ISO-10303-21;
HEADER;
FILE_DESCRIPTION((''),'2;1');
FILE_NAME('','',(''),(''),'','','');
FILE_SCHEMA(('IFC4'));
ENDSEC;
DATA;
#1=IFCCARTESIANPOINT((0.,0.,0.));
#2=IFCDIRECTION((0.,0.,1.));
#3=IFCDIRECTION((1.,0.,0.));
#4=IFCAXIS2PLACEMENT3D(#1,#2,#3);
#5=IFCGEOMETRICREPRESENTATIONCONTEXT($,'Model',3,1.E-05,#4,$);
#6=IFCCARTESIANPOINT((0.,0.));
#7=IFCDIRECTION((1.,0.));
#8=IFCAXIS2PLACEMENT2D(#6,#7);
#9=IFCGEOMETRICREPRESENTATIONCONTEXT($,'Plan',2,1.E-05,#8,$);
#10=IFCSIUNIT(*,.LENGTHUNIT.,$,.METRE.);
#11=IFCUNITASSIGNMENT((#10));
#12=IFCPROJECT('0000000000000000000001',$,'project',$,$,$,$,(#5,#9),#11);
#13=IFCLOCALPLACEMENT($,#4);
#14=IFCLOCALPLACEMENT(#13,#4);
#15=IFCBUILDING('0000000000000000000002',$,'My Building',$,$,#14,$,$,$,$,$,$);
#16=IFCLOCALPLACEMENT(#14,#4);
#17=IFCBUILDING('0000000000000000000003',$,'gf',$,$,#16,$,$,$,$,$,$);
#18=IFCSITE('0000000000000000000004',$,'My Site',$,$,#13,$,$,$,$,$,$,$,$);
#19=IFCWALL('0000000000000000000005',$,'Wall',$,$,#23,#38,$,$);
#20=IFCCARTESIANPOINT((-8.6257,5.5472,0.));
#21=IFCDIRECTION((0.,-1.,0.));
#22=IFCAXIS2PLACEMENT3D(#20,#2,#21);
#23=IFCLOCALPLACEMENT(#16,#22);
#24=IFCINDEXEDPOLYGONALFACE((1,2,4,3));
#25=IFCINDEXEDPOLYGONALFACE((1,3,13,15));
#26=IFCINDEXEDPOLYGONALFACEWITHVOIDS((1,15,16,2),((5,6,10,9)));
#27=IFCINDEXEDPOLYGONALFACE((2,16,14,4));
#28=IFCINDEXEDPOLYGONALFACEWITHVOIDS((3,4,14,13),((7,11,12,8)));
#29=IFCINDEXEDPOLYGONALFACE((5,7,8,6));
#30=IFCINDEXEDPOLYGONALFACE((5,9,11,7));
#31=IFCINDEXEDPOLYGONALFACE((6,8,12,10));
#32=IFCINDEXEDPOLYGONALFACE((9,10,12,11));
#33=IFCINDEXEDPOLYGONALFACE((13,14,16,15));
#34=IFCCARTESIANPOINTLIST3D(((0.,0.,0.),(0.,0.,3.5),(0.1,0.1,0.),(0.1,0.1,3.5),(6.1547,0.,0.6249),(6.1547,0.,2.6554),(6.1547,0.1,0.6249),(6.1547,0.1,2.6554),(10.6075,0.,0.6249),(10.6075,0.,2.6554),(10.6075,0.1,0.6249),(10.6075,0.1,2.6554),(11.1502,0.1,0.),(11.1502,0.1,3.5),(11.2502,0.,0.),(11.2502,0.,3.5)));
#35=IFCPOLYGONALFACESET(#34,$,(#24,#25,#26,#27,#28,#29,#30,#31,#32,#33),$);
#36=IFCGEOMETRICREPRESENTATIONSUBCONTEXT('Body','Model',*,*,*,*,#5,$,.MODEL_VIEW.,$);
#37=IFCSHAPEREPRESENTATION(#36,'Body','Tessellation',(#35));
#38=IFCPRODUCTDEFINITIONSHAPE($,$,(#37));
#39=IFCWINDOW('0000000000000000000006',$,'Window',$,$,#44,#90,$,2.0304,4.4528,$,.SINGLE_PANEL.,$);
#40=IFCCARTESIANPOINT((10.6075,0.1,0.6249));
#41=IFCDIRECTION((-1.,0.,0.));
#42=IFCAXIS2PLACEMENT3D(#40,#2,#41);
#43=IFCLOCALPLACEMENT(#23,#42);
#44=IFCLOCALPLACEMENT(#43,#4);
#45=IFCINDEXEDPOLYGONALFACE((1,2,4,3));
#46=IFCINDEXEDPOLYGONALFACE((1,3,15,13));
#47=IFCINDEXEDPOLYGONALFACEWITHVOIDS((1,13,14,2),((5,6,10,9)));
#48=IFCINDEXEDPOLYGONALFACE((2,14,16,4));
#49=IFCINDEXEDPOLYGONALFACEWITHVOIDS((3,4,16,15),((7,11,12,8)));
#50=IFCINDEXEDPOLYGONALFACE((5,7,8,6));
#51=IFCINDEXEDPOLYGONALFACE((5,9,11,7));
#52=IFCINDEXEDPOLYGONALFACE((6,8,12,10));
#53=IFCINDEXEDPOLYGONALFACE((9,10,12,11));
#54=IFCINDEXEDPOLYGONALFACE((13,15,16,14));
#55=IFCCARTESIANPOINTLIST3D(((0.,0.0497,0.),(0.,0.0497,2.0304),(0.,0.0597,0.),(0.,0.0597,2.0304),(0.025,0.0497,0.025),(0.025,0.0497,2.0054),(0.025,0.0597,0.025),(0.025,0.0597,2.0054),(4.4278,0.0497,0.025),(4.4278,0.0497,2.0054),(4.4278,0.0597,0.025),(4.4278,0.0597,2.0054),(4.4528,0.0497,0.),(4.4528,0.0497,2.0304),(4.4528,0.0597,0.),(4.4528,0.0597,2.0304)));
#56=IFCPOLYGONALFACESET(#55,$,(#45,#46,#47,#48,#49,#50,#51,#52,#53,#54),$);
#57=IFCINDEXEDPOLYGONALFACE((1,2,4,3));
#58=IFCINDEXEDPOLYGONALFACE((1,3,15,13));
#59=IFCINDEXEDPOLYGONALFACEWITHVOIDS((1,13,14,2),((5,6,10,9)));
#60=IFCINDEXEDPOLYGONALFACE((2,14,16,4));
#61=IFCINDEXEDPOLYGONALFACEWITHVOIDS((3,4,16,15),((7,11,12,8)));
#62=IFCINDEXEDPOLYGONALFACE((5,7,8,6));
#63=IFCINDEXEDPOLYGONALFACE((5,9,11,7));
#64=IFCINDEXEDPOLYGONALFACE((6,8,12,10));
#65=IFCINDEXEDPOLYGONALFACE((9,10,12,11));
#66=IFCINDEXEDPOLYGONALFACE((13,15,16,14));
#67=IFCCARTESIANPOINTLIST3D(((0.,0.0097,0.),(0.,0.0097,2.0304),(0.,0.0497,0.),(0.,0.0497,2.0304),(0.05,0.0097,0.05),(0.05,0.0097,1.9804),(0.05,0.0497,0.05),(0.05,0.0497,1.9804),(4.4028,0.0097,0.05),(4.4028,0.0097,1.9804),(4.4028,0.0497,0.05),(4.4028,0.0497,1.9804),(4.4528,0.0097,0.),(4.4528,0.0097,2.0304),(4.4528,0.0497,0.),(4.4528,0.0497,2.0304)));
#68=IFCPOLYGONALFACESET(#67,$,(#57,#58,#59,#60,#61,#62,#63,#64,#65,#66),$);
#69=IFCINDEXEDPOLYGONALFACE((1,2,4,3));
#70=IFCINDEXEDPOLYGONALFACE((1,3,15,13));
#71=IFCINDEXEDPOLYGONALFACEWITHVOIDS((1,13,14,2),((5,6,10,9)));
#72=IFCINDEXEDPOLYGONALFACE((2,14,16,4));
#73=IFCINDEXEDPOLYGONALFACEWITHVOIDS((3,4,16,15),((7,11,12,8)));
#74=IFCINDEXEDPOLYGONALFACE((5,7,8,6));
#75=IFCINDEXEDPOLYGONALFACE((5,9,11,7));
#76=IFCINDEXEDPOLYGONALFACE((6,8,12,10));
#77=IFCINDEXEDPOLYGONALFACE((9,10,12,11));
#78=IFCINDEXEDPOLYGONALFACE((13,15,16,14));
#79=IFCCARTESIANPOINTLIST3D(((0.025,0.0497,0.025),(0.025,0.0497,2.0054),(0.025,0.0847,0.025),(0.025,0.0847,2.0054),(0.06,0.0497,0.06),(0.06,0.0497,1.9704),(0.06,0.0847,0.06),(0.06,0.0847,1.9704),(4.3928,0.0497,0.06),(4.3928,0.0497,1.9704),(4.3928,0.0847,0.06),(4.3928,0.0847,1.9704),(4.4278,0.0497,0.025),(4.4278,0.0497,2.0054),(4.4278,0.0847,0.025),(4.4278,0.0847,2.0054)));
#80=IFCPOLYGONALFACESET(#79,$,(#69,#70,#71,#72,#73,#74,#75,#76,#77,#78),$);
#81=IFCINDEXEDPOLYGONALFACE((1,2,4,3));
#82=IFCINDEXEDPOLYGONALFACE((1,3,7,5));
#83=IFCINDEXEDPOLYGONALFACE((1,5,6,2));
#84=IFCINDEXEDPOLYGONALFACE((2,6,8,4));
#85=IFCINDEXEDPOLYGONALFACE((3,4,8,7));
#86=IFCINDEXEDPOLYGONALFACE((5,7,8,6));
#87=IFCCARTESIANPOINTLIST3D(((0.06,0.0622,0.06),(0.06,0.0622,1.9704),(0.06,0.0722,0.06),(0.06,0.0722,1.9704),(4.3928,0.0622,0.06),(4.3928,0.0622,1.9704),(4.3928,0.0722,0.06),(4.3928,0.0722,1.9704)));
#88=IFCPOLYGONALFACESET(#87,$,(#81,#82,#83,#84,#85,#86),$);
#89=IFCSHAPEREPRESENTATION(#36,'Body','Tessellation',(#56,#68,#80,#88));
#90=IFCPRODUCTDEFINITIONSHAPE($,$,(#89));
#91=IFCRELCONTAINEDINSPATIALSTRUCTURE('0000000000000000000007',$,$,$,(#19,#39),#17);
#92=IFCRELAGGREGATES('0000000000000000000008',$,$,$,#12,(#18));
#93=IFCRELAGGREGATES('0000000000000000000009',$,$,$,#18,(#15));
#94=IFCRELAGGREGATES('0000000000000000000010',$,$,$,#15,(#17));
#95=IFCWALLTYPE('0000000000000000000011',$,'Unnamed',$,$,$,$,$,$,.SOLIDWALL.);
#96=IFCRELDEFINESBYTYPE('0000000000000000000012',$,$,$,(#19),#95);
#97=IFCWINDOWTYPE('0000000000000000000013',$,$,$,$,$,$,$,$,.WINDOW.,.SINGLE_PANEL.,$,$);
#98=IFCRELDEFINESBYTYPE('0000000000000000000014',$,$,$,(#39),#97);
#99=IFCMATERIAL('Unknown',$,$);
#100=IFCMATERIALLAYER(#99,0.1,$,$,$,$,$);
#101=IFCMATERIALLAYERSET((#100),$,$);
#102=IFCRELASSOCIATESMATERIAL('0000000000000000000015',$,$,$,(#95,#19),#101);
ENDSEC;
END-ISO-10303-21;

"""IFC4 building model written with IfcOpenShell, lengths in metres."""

from ifc_helpers import new_model, entity, si_unit, frame, origin_with_axes, origin_2d_with_axis, place, context, subcontext, project, spatial, line, indexed_curve, outline, extrude, shape, source, transform, mapped, material, layer, layer_set, layer_usage, type_object, type_shapes, element, fill, save


model = new_model("IFC4")

# Units and contexts
model_context = context("Model", 3, precision=1e-05, world=origin_with_axes())
plan_context = context("Plan", 2, precision=1e-05, world=origin_2d_with_axis())
body_context_1 = subcontext(model_context, "Body", "Model", "MODEL_VIEW")
body_context_2 = subcontext(plan_context, "Body", "Plan", "PLAN_VIEW")
ifc_project = project(units=[si_unit("LENGTHUNIT", "METRE")], contexts=[model_context, plan_context])

# Site, buildings
site_placement = place(None, origin_with_axes())
site = spatial("IfcSite", under=ifc_project, at=site_placement, Name="My Site")
building_1_placement = place(site_placement, origin_with_axes())
building_1 = spatial("IfcBuilding", under=site, at=building_1_placement, Name="My Building")
building_2_placement = place(building_1_placement, origin_with_axes())
building_2 = spatial("IfcBuilding", under=building_1, at=building_2_placement, Name="gf")

# Shared definitions
ifc_material = material(Name="Unknown")

# Wall, opening, window
ifc_layer_1 = layer(ifc_material, 0.1)
ifc_layer_set_1 = layer_set([ifc_layer_1])
ifc_layer_usage_1 = layer_usage(ifc_layer_set_1, "AXIS2", "POSITIVE", 0.0)
wall_type = type_object("IfcWallType", Name="Unnamed", PredefinedType="SOLIDWALL", material=ifc_layer_set_1)
wall_1_placement = place(building_2_placement, frame((-8.6257, 5.5472, 0.0), z_axis=(0.0, 0.0, 1.0), x_axis=(0.0, -1.0, 0.0)))
wall_1 = element("IfcWall", 1, at=wall_1_placement, inside=building_2, type_object=wall_type, material=ifc_layer_usage_1, Name="Wall", context=body_context_1, shape_type="SweptSolid", body=[
    extrude(outline(indexed_curve([(0.0, 0.0), (0.1, 0.1), (11.1502, 0.1), (11.2502, 0.0)], segments=[line(1, 2, 3, 4, 1)])), origin_with_axes(), (0.0, 0.0, 1.0), 3.5),
])
shared_shape_1 = source(origin_with_axes(), body_context_1, "Body", "SweptSolid", [
    extrude(outline(indexed_curve([(0.0, 0.0), (4.4528, 0.0), (4.4528, 2.0304), (0.0, 2.0304)], segments=[line(1, 2, 3, 4, 1)])), frame((0.0, -0.6, 0.0), z_axis=(0.0, -1.0, 0.0), x_axis=(1.0, 0.0, 0.0)), (0.0, 0.0, -1.0), 1.2),
])
opening_1_placement = place(wall_1_placement, frame((10.6075, 0.1, 0.6249), z_axis=(0.0, 0.0, 1.0), x_axis=(-1.0, 0.0, 0.0)))
opening_1 = element("IfcOpeningElement", 2, at=opening_1_placement, cuts=wall_1, PredefinedType="OPENING", context=body_context_1, shape_type="MappedRepresentation", body=[
    mapped(shared_shape_1, transform((0.0, 0.0, 0.0), x_axis=(1.0, 0.0, 0.0), y_axis=(0.0, 1.0, 0.0), z_axis=(0.0, 0.0, 1.0), scale=1.0)),
])
window_type_1 = type_object("IfcWindowType", PartitioningType="SINGLE_PANEL", PredefinedType="WINDOW")
shared_shape_2 = source(origin_with_axes(), body_context_1, "Body", "SweptSolid", [
    extrude(outline(indexed_curve([(0.0, 0.0), (4.4528, 0.0), (4.4528, 2.0304), (0.0, 2.0304)], segments=[line(1, 2, 3, 4, 1)]), holes=[indexed_curve([(0.025, 0.025), (4.4278, 0.025), (4.4278, 2.0054), (0.025, 2.0054)], segments=[line(1, 2, 3, 4, 1)])]), frame((0.0, 0.0497, 0.0), z_axis=(0.0, -1.0, 0.0), x_axis=(1.0, 0.0, 0.0)), (0.0, 0.0, -1.0), 0.01),
    extrude(outline(indexed_curve([(0.0, 0.0), (4.4528, 0.0), (4.4528, 2.0304), (0.0, 2.0304)], segments=[line(1, 2, 3, 4, 1)]), holes=[indexed_curve([(0.05, 0.05), (4.4028, 0.05), (4.4028, 1.9804), (0.05, 1.9804)], segments=[line(1, 2, 3, 4, 1)])]), frame((0.0, 0.0097, 0.0), z_axis=(0.0, -1.0, 0.0), x_axis=(1.0, 0.0, 0.0)), (0.0, 0.0, -1.0), 0.04),
    extrude(outline(indexed_curve([(0.0, 0.0), (4.4028, 0.0), (4.4028, 1.9804), (0.0, 1.9804)], segments=[line(1, 2, 3, 4, 1)]), holes=[indexed_curve([(0.035, 0.035), (4.3678, 0.035), (4.3678, 1.9454), (0.035, 1.9454)], segments=[line(1, 2, 3, 4, 1)])]), frame((0.025, 0.0497, 0.025), z_axis=(0.0, -1.0, 0.0), x_axis=(1.0, 0.0, 0.0)), (0.0, 0.0, -1.0), 0.035),
    extrude(outline(indexed_curve([(0.035, 0.035), (4.3678, 0.035), (4.3678, 1.9454), (0.035, 1.9454)], segments=[line(1, 2, 3, 4, 1)])), frame((0.025, 0.0622, 0.025), z_axis=(0.0, -1.0, 0.0), x_axis=(1.0, 0.0, 0.0)), (0.0, 0.0, -1.0), 0.01),
])
shared_shape_3 = source(origin_with_axes(), body_context_2, "Body", "Curve2D", [
    entity("IfcIndexedPolyCurve", entity("IfcCartesianPointList2D", [[0.05, 0.0097], [4.4028, 0.0097]])),
    entity("IfcIndexedPolyCurve", entity("IfcCartesianPointList2D", [[0.0, 0.0597], [0.025, 0.0597], [0.025, 0.0497], [0.05, 0.0497], [0.05, 0.0097], [0.0, 0.0097]]), [entity("IfcLineIndex", [1, 2, 3, 4, 5, 6, 1])]),
    entity("IfcIndexedPolyCurve", entity("IfcCartesianPointList2D", [[4.4528, 0.0597], [4.4278, 0.0597], [4.4278, 0.0497], [4.4028, 0.0497], [4.4028, 0.0097], [4.4528, 0.0097]]), [entity("IfcLineIndex", [1, 2, 3, 4, 5, 6, 1])]),
    entity("IfcIndexedPolyCurve", entity("IfcCartesianPointList2D", [[0.025, 0.0497], [0.06, 0.0497], [0.06, 0.0847], [0.025, 0.0847]]), [entity("IfcLineIndex", [1, 2, 3, 4, 1])]),
    entity("IfcIndexedPolyCurve", entity("IfcCartesianPointList2D", [[4.4278, 0.0497], [4.3928, 0.0497], [4.3928, 0.0847], [4.4278, 0.0847]]), [entity("IfcLineIndex", [1, 2, 3, 4, 1])]),
    entity("IfcIndexedPolyCurve", entity("IfcCartesianPointList2D", [[0.06, 0.0497], [4.3928, 0.0497]])),
    entity("IfcIndexedPolyCurve", entity("IfcCartesianPointList2D", [[0.06, 0.0847], [4.3928, 0.0847]])),
    entity("IfcIndexedPolyCurve", entity("IfcCartesianPointList2D", [[0.06, 0.0672], [4.3928, 0.0672]])),
])
type_shapes(window_type_1, [shared_shape_2, shared_shape_3])
window_1_placement = place(opening_1_placement, frame((0.0, 0.0, 0.0), z_axis=(0.0, 0.0, 1.0), x_axis=(1.0, 0.0, 0.0)))
window_1 = element("IfcWindow", 3, at=window_1_placement, inside=building_2, type_object=window_type_1, Name="Window", OverallHeight=2.0304, OverallWidth=4.4528, PartitioningType="SINGLE_PANEL", shapes=[
    shape(body_context_1, "Body", "MappedRepresentation", [mapped(shared_shape_2, transform((0.0, 0.0, 0.0), x_axis=(1.0, 0.0, 0.0), y_axis=(0.0, 1.0, 0.0), z_axis=(0.0, 0.0, 1.0), scale=1.0))]),
    shape(body_context_2, "Body", "MappedRepresentation", [mapped(shared_shape_3, transform((0.0, 0.0, 0.0), x_axis=(1.0, 0.0, 0.0), y_axis=(0.0, 1.0, 0.0), z_axis=(0.0, 0.0, 1.0), scale=1.0))]),
])
fill(opening_1, window_1)

save(model, "model.ifc")
